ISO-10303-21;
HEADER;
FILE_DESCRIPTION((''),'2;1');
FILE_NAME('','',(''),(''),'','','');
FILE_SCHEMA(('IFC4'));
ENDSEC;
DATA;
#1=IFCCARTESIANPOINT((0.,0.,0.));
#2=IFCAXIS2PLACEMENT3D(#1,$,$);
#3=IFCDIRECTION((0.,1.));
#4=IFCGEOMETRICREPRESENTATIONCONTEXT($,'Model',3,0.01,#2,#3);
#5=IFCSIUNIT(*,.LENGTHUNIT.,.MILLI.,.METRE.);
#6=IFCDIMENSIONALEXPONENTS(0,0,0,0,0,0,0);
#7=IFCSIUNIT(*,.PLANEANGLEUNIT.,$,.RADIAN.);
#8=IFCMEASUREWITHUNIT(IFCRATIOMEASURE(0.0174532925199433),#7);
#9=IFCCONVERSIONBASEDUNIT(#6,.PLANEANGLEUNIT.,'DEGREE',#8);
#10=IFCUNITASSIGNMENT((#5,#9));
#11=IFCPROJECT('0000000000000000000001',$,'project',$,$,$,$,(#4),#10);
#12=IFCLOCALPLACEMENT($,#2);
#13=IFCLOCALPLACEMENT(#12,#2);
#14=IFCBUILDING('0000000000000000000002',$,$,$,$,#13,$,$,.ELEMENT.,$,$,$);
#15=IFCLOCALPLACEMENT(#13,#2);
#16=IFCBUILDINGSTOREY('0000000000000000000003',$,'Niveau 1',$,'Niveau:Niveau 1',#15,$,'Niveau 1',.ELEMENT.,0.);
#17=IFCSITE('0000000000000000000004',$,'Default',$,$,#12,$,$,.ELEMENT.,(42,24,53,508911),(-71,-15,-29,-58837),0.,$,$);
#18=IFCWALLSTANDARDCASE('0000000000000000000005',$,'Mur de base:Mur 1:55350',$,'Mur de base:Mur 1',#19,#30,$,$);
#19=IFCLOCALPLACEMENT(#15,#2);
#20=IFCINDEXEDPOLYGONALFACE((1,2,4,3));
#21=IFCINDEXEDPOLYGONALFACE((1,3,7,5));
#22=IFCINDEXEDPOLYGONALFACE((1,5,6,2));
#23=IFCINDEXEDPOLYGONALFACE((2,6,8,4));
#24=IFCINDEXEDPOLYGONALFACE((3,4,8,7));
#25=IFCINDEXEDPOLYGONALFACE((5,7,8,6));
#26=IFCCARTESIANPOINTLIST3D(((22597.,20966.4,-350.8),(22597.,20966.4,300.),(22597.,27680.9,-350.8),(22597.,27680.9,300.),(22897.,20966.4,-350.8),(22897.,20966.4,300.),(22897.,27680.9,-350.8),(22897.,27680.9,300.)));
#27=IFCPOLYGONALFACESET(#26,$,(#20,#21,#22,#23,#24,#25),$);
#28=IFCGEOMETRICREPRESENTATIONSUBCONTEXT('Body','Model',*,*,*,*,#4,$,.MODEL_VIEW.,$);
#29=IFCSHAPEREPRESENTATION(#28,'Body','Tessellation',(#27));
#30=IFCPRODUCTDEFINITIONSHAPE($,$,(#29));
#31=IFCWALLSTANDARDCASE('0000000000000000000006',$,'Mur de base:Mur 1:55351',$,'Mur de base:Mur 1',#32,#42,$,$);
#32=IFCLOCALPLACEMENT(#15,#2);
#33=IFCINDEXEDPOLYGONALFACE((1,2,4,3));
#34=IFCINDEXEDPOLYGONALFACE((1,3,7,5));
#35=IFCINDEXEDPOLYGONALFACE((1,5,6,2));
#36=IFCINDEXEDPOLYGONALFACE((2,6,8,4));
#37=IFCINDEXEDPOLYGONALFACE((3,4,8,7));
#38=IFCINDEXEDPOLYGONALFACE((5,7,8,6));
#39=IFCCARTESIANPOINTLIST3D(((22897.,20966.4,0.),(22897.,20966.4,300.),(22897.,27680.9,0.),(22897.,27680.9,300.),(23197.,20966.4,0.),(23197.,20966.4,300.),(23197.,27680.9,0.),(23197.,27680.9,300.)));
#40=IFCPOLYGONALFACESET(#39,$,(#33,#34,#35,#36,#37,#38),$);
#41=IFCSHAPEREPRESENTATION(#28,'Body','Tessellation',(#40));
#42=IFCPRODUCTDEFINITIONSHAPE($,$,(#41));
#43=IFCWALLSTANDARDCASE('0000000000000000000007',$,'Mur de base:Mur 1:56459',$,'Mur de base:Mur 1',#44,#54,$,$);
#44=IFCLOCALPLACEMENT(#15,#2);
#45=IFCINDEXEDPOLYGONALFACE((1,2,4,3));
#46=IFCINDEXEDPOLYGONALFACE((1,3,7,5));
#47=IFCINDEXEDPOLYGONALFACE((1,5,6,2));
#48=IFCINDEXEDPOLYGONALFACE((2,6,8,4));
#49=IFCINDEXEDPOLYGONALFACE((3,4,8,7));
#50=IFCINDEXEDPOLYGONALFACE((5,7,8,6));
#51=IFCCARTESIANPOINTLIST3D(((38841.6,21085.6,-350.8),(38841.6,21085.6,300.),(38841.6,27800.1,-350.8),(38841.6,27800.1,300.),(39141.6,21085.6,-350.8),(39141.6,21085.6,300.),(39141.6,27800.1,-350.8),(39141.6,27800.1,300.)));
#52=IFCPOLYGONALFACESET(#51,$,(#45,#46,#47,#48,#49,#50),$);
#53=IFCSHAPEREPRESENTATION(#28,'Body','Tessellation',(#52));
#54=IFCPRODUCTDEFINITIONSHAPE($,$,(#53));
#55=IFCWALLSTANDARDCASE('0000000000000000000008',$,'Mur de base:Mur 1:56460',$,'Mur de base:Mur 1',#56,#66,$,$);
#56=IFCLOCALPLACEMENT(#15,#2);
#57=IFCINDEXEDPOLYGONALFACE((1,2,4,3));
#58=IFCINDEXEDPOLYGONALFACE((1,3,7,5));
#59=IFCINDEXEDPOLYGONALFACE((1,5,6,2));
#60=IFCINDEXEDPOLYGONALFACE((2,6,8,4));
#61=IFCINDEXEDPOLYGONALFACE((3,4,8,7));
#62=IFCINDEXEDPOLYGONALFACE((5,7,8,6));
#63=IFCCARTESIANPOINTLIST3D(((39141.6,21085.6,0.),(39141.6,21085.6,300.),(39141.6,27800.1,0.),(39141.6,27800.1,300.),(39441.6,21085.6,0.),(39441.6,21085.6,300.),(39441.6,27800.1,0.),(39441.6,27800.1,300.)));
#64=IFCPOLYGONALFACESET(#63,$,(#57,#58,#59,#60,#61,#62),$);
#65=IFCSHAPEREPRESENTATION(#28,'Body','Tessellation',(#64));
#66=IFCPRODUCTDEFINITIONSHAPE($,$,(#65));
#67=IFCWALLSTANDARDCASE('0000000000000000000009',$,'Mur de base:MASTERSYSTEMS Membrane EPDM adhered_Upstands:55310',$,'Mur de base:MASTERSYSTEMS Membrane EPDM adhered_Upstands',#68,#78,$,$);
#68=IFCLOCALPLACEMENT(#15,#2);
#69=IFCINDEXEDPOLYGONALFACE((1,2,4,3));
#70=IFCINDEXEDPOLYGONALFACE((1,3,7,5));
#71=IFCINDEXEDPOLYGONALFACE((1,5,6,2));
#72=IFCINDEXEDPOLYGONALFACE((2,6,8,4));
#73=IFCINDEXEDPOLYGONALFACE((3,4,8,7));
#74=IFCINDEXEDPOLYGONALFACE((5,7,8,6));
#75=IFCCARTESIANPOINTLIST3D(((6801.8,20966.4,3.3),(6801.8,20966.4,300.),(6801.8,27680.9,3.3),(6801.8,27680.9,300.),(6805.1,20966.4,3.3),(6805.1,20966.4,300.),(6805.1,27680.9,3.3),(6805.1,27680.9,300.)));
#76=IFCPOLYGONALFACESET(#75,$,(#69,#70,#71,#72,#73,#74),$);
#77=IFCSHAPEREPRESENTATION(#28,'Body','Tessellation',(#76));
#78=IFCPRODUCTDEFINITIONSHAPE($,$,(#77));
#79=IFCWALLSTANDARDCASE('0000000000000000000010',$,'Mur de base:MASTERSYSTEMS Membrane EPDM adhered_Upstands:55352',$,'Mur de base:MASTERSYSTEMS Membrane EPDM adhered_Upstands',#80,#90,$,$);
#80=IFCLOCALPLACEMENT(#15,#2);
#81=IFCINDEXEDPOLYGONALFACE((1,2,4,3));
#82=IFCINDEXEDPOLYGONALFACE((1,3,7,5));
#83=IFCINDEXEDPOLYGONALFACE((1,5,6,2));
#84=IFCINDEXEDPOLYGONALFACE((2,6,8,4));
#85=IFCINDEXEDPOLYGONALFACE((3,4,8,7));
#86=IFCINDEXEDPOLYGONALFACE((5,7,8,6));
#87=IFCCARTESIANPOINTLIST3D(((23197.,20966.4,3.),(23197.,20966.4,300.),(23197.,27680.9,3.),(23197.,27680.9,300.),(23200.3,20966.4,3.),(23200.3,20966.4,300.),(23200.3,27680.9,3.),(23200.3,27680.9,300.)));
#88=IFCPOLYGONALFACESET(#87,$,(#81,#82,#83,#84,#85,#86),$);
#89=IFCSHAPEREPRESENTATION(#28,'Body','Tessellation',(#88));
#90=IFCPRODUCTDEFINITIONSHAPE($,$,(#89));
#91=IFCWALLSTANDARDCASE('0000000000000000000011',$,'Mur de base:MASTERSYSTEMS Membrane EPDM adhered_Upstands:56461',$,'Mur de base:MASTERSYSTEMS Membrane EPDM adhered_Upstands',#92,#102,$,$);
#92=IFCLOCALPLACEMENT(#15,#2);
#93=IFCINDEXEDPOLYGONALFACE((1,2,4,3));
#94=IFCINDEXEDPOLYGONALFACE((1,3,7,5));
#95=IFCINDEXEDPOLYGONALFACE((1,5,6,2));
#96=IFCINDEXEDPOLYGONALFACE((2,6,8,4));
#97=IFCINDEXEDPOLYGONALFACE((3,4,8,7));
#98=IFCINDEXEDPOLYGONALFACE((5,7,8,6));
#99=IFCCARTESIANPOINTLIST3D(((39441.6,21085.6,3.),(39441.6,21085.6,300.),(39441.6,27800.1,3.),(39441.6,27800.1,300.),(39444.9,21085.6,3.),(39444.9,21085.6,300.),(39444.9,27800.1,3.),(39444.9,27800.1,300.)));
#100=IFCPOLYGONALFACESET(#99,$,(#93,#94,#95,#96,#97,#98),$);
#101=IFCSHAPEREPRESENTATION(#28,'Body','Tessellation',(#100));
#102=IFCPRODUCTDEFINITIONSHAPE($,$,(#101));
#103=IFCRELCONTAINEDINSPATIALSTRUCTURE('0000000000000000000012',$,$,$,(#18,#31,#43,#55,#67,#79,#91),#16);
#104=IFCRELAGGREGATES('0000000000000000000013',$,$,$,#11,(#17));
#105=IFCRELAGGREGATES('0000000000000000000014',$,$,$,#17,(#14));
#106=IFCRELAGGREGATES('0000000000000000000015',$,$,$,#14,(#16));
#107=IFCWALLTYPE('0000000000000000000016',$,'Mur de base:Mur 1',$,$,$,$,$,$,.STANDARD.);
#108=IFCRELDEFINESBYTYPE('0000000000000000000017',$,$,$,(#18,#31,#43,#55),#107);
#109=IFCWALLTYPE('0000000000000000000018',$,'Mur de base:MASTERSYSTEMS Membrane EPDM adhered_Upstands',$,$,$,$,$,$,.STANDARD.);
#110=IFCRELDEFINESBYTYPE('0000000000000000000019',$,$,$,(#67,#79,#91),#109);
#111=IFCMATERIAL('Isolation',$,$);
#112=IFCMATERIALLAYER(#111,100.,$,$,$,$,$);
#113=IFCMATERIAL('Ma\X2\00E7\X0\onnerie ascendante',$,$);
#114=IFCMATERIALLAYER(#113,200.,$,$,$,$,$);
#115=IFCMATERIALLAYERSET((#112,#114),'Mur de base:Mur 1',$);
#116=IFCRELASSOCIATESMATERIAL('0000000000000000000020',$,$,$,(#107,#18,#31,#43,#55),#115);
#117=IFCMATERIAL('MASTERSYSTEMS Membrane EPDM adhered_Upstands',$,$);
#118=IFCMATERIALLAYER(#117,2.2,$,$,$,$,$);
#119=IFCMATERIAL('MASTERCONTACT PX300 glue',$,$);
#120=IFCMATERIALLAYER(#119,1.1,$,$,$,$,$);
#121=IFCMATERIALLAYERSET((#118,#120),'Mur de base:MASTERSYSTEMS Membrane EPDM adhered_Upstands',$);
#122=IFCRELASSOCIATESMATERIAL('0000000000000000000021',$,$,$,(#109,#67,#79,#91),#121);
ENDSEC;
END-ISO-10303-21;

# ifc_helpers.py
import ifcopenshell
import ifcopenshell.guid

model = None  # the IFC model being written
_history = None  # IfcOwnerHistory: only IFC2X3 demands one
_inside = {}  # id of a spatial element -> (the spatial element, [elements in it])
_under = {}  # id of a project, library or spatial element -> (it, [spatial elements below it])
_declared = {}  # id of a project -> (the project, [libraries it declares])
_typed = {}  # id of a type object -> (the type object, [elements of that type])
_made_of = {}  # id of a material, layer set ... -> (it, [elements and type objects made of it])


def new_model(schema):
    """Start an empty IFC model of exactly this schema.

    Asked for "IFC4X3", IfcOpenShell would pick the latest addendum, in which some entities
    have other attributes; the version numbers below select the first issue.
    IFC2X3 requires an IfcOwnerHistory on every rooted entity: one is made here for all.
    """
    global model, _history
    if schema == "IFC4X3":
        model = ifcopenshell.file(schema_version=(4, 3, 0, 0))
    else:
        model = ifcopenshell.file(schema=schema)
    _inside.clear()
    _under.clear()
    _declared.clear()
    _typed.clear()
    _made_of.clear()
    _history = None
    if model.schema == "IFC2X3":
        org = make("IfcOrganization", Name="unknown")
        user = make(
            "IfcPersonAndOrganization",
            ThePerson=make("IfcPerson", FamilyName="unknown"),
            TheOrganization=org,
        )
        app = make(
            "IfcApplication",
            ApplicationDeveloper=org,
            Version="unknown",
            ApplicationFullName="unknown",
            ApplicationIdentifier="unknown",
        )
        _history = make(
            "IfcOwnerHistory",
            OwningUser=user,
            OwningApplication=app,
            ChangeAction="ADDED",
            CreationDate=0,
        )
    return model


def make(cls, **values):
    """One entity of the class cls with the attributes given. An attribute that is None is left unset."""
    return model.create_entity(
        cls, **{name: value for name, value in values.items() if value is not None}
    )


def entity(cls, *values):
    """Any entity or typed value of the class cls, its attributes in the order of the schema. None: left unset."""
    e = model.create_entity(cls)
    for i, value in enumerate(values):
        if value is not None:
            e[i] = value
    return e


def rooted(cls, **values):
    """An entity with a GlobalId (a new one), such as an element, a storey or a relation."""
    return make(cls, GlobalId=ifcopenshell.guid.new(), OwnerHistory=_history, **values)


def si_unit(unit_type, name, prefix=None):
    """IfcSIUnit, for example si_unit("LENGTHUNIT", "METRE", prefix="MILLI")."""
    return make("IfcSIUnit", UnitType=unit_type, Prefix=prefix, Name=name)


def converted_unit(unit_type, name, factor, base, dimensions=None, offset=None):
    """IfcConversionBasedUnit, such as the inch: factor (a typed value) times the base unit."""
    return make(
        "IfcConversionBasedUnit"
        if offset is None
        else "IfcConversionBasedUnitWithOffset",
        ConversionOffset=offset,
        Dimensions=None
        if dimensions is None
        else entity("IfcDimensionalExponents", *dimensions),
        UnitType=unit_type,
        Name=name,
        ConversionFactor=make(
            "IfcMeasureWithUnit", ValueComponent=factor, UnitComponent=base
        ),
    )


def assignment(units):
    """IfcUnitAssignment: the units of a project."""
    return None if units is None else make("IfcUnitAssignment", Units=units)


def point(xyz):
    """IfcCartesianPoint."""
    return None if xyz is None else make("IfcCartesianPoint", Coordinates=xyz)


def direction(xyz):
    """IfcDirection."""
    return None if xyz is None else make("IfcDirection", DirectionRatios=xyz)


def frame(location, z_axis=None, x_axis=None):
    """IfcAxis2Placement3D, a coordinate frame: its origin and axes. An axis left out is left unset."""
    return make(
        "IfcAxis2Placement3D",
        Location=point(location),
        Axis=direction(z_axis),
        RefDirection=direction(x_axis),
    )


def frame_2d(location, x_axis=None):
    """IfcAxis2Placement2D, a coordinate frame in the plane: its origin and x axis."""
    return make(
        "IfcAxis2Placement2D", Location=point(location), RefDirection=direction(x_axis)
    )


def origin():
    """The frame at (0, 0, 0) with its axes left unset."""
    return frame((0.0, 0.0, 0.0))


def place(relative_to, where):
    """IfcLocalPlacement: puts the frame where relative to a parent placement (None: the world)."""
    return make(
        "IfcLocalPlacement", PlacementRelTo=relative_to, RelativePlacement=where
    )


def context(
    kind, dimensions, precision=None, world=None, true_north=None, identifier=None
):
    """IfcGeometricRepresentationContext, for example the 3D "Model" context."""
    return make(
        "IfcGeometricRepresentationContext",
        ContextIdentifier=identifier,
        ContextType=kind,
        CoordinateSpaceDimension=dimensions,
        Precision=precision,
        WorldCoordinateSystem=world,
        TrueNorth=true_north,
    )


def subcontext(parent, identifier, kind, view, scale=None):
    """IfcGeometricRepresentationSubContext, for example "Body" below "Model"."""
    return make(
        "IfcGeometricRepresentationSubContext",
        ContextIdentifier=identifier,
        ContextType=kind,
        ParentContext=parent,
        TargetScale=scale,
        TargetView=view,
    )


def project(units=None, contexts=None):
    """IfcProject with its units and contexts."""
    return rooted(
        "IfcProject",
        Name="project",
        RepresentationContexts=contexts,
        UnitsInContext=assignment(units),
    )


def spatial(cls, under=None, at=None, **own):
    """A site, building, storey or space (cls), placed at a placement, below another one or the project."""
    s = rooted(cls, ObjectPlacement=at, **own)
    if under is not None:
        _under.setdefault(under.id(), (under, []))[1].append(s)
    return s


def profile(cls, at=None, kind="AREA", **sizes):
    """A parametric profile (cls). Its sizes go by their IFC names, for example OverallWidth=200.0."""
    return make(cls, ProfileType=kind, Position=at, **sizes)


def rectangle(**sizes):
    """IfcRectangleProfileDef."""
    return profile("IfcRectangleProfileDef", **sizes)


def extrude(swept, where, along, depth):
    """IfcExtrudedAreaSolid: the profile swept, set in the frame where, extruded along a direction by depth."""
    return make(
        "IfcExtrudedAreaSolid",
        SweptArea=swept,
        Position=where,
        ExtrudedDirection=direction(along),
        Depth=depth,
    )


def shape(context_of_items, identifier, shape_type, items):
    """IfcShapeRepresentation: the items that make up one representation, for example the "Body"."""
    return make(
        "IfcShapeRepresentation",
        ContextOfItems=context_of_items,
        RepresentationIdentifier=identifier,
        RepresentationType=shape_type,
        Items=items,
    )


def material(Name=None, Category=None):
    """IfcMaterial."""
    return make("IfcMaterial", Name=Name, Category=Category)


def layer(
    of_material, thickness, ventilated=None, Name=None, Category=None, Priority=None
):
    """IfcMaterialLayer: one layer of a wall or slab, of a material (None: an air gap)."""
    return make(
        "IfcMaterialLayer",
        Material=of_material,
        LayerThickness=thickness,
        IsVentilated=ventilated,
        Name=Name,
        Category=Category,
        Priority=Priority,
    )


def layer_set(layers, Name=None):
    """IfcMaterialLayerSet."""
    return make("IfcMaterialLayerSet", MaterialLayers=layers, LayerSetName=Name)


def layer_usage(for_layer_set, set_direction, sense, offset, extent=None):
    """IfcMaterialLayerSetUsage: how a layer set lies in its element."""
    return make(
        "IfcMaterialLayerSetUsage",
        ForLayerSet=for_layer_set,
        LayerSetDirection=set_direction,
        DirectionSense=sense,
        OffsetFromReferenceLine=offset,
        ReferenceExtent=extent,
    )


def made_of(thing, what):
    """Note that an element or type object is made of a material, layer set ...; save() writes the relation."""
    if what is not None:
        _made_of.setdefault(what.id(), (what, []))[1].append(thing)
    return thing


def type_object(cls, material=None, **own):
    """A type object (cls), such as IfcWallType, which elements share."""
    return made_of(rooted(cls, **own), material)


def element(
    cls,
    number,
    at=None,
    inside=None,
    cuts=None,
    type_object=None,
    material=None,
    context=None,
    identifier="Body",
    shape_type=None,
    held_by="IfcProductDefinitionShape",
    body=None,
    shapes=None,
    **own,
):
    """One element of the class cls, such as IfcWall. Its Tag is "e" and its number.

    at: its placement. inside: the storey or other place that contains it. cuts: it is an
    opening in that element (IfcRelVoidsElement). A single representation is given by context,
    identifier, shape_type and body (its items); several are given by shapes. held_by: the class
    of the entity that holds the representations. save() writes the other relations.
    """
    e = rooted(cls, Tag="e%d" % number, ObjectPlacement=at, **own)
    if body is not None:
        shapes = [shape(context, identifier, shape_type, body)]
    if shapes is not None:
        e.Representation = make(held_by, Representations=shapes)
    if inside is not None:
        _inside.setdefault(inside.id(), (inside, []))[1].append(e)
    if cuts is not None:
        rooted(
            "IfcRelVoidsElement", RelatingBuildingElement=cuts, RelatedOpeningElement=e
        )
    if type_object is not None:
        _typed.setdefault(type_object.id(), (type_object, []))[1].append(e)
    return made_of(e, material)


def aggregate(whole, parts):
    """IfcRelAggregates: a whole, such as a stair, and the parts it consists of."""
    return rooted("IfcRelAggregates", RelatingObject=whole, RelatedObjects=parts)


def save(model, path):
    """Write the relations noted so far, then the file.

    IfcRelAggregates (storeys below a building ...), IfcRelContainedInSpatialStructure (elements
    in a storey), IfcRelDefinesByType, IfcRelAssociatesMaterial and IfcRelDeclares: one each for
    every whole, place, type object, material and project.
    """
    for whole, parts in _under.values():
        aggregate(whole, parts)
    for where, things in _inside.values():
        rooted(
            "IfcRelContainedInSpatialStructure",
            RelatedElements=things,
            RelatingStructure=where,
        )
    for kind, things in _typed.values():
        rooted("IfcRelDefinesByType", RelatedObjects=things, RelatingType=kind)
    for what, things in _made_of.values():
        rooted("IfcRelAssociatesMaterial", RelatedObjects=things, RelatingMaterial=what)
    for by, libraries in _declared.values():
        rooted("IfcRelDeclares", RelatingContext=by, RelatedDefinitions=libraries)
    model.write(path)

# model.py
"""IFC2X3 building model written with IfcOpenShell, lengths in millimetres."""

from ifc_helpers import new_model, entity, si_unit, converted_unit, direction, frame, frame_2d, origin, place, context, subcontext, project, spatial, rectangle, extrude, material, layer, layer_set, layer_usage, type_object, element, save


model = new_model("IFC2X3")

# Units and contexts
model_context = context("Model", 3, precision=0.01, world=origin(), true_north=direction((0.0, 1.0)))
body_context = subcontext(model_context, "Body", "Model", "MODEL_VIEW")
ifc_project = project(units=[si_unit("LENGTHUNIT", "METRE", prefix="MILLI"), converted_unit("PLANEANGLEUNIT", "DEGREE", entity("IfcRatioMeasure", 0.0174532925199433), si_unit("PLANEANGLEUNIT", "RADIAN"), dimensions=[0, 0, 0, 0, 0, 0, 0])], contexts=[model_context])

# Site, building, storey
site_placement = place(None, origin())
site = spatial("IfcSite", under=ifc_project, at=site_placement, Name="Default", CompositionType="ELEMENT", RefLatitude=(42, 24, 53, 508911), RefLongitude=(-71, -15, -29, -58837), RefElevation=0.0)
building_placement = place(site_placement, origin())
building = spatial("IfcBuilding", under=site, at=building_placement, CompositionType="ELEMENT")
storey_placement = place(building_placement, origin())
storey = spatial("IfcBuildingStorey", under=building, at=storey_placement, Name="Niveau 1", ObjectType="Niveau:Niveau 1", LongName="Niveau 1", CompositionType="ELEMENT", Elevation=0.0)

# Shared definitions
ifc_material_1 = material(Name="MASTERCONTACT PX300 glue")
ifc_material_2 = material(Name="Isolation")
ifc_material_3 = material(Name="MASTERSYSTEMS Membrane EPDM adhered_Upstands")

# Walls
ifc_layer_1 = layer(ifc_material_2, 100.0)
ifc_material_4 = material(Name="Maçonnerie ascendante")
ifc_layer_2 = layer(ifc_material_4, 200.0)
ifc_layer_set_1 = layer_set([ifc_layer_1, ifc_layer_2], Name="Mur de base:Mur 1")
wall_type_1 = type_object("IfcWallType", Name="Mur de base:Mur 1", PredefinedType="STANDARD", material=ifc_layer_set_1)
ifc_layer_usage_1 = layer_usage(ifc_layer_set_1, "AXIS2", "NEGATIVE", 150.0)
wall_1_placement = place(storey_placement, frame((22747.0, 27680.9, -350.8), z_axis=(0.0, 0.0, 1.0), x_axis=(0.0, -1.0, 0.0)))
element("IfcWallStandardCase", 1, at=wall_1_placement, inside=storey, type_object=wall_type_1, material=ifc_layer_usage_1, Name="Mur de base:Mur 1:55350", ObjectType="Mur de base:Mur 1", context=body_context, shape_type="SweptSolid", body=[
    extrude(rectangle(XDim=6714.5, YDim=300.0, at=frame_2d((3357.2, 0.0), x_axis=(-1.0, 0.0))), origin(), (0.0, 0.0, 1.0), 650.8),
])
ifc_layer_usage_2 = layer_usage(ifc_layer_set_1, "AXIS2", "NEGATIVE", 150.0)
wall_2_placement = place(storey_placement, frame((23047.0, 27680.9, 0.0), z_axis=(0.0, 0.0, 1.0), x_axis=(0.0, -1.0, 0.0)))
element("IfcWallStandardCase", 2, at=wall_2_placement, inside=storey, type_object=wall_type_1, material=ifc_layer_usage_2, Name="Mur de base:Mur 1:55351", ObjectType="Mur de base:Mur 1", context=body_context, shape_type="SweptSolid", body=[
    extrude(rectangle(XDim=6714.5, YDim=300.0, at=frame_2d((3357.2, 0.0), x_axis=(-1.0, 0.0))), origin(), (0.0, 0.0, 1.0), 300.0),
])
ifc_layer_usage_3 = layer_usage(ifc_layer_set_1, "AXIS2", "NEGATIVE", 150.0)
wall_3_placement = place(storey_placement, frame((38991.6, 27800.1, -350.8), z_axis=(0.0, 0.0, 1.0), x_axis=(0.0, -1.0, 0.0)))
element("IfcWallStandardCase", 3, at=wall_3_placement, inside=storey, type_object=wall_type_1, material=ifc_layer_usage_3, Name="Mur de base:Mur 1:56459", ObjectType="Mur de base:Mur 1", context=body_context, shape_type="SweptSolid", body=[
    extrude(rectangle(XDim=6714.5, YDim=300.0, at=frame_2d((3357.2, 0.0), x_axis=(-1.0, 0.0))), origin(), (0.0, 0.0, 1.0), 650.8),
])
ifc_layer_usage_4 = layer_usage(ifc_layer_set_1, "AXIS2", "NEGATIVE", 150.0)
wall_4_placement = place(storey_placement, frame((39291.6, 27800.1, 0.0), z_axis=(0.0, 0.0, 1.0), x_axis=(0.0, -1.0, 0.0)))
element("IfcWallStandardCase", 4, at=wall_4_placement, inside=storey, type_object=wall_type_1, material=ifc_layer_usage_4, Name="Mur de base:Mur 1:56460", ObjectType="Mur de base:Mur 1", context=body_context, shape_type="SweptSolid", body=[
    extrude(rectangle(XDim=6714.5, YDim=300.0, at=frame_2d((3357.2, 0.0), x_axis=(-1.0, 0.0))), origin(), (0.0, 0.0, 1.0), 300.0),
])
ifc_layer_3 = layer(ifc_material_3, 2.2)
ifc_layer_4 = layer(ifc_material_1, 1.1)
ifc_layer_set_2 = layer_set([ifc_layer_3, ifc_layer_4], Name="Mur de base:MASTERSYSTEMS Membrane EPDM adhered_Upstands")
ifc_layer_usage_5 = layer_usage(ifc_layer_set_2, "AXIS2", "NEGATIVE", 1.6)
wall_type_2 = type_object("IfcWallType", Name="Mur de base:MASTERSYSTEMS Membrane EPDM adhered_Upstands", PredefinedType="STANDARD", material=ifc_layer_set_2)
wall_5_placement = place(storey_placement, frame((6803.4, 20966.4, 3.3), z_axis=(0.0, 0.0, 1.0), x_axis=(0.0, 1.0, 0.0)))
element("IfcWallStandardCase", 5, at=wall_5_placement, inside=storey, type_object=wall_type_2, material=ifc_layer_usage_5, Name="Mur de base:MASTERSYSTEMS Membrane EPDM adhered_Upstands:55310", ObjectType="Mur de base:MASTERSYSTEMS Membrane EPDM adhered_Upstands", context=body_context, shape_type="SweptSolid", body=[
    extrude(rectangle(XDim=6714.5, YDim=3.3, at=frame_2d((3357.2, 0.0), x_axis=(-1.0, 0.0))), origin(), (0.0, 0.0, 1.0), 296.7),
])
ifc_layer_usage_6 = layer_usage(ifc_layer_set_2, "AXIS2", "NEGATIVE", 1.6)
wall_6_placement = place(storey_placement, frame((23198.6, 20966.4, 3.0), z_axis=(0.0, 0.0, 1.0), x_axis=(0.0, 1.0, 0.0)))
element("IfcWallStandardCase", 6, at=wall_6_placement, inside=storey, type_object=wall_type_2, material=ifc_layer_usage_6, Name="Mur de base:MASTERSYSTEMS Membrane EPDM adhered_Upstands:55352", ObjectType="Mur de base:MASTERSYSTEMS Membrane EPDM adhered_Upstands", context=body_context, shape_type="SweptSolid", body=[
    extrude(rectangle(XDim=6714.5, YDim=3.3, at=frame_2d((3357.2, 0.0), x_axis=(-1.0, 0.0))), origin(), (0.0, 0.0, 1.0), 297.0),
])
ifc_layer_usage_7 = layer_usage(ifc_layer_set_2, "AXIS2", "NEGATIVE", 1.6)
wall_7_placement = place(storey_placement, frame((39443.3, 21085.6, 3.0), z_axis=(0.0, 0.0, 1.0), x_axis=(0.0, 1.0, 0.0)))
element("IfcWallStandardCase", 7, at=wall_7_placement, inside=storey, type_object=wall_type_2, material=ifc_layer_usage_7, Name="Mur de base:MASTERSYSTEMS Membrane EPDM adhered_Upstands:56461", ObjectType="Mur de base:MASTERSYSTEMS Membrane EPDM adhered_Upstands", context=body_context, shape_type="SweptSolid", body=[
    extrude(rectangle(XDim=6714.5, YDim=3.3, at=frame_2d((3357.2, 0.0), x_axis=(-1.0, 0.0))), origin(), (0.0, 0.0, 1.0), 297.0),
])

save(model, "model.ifc")
